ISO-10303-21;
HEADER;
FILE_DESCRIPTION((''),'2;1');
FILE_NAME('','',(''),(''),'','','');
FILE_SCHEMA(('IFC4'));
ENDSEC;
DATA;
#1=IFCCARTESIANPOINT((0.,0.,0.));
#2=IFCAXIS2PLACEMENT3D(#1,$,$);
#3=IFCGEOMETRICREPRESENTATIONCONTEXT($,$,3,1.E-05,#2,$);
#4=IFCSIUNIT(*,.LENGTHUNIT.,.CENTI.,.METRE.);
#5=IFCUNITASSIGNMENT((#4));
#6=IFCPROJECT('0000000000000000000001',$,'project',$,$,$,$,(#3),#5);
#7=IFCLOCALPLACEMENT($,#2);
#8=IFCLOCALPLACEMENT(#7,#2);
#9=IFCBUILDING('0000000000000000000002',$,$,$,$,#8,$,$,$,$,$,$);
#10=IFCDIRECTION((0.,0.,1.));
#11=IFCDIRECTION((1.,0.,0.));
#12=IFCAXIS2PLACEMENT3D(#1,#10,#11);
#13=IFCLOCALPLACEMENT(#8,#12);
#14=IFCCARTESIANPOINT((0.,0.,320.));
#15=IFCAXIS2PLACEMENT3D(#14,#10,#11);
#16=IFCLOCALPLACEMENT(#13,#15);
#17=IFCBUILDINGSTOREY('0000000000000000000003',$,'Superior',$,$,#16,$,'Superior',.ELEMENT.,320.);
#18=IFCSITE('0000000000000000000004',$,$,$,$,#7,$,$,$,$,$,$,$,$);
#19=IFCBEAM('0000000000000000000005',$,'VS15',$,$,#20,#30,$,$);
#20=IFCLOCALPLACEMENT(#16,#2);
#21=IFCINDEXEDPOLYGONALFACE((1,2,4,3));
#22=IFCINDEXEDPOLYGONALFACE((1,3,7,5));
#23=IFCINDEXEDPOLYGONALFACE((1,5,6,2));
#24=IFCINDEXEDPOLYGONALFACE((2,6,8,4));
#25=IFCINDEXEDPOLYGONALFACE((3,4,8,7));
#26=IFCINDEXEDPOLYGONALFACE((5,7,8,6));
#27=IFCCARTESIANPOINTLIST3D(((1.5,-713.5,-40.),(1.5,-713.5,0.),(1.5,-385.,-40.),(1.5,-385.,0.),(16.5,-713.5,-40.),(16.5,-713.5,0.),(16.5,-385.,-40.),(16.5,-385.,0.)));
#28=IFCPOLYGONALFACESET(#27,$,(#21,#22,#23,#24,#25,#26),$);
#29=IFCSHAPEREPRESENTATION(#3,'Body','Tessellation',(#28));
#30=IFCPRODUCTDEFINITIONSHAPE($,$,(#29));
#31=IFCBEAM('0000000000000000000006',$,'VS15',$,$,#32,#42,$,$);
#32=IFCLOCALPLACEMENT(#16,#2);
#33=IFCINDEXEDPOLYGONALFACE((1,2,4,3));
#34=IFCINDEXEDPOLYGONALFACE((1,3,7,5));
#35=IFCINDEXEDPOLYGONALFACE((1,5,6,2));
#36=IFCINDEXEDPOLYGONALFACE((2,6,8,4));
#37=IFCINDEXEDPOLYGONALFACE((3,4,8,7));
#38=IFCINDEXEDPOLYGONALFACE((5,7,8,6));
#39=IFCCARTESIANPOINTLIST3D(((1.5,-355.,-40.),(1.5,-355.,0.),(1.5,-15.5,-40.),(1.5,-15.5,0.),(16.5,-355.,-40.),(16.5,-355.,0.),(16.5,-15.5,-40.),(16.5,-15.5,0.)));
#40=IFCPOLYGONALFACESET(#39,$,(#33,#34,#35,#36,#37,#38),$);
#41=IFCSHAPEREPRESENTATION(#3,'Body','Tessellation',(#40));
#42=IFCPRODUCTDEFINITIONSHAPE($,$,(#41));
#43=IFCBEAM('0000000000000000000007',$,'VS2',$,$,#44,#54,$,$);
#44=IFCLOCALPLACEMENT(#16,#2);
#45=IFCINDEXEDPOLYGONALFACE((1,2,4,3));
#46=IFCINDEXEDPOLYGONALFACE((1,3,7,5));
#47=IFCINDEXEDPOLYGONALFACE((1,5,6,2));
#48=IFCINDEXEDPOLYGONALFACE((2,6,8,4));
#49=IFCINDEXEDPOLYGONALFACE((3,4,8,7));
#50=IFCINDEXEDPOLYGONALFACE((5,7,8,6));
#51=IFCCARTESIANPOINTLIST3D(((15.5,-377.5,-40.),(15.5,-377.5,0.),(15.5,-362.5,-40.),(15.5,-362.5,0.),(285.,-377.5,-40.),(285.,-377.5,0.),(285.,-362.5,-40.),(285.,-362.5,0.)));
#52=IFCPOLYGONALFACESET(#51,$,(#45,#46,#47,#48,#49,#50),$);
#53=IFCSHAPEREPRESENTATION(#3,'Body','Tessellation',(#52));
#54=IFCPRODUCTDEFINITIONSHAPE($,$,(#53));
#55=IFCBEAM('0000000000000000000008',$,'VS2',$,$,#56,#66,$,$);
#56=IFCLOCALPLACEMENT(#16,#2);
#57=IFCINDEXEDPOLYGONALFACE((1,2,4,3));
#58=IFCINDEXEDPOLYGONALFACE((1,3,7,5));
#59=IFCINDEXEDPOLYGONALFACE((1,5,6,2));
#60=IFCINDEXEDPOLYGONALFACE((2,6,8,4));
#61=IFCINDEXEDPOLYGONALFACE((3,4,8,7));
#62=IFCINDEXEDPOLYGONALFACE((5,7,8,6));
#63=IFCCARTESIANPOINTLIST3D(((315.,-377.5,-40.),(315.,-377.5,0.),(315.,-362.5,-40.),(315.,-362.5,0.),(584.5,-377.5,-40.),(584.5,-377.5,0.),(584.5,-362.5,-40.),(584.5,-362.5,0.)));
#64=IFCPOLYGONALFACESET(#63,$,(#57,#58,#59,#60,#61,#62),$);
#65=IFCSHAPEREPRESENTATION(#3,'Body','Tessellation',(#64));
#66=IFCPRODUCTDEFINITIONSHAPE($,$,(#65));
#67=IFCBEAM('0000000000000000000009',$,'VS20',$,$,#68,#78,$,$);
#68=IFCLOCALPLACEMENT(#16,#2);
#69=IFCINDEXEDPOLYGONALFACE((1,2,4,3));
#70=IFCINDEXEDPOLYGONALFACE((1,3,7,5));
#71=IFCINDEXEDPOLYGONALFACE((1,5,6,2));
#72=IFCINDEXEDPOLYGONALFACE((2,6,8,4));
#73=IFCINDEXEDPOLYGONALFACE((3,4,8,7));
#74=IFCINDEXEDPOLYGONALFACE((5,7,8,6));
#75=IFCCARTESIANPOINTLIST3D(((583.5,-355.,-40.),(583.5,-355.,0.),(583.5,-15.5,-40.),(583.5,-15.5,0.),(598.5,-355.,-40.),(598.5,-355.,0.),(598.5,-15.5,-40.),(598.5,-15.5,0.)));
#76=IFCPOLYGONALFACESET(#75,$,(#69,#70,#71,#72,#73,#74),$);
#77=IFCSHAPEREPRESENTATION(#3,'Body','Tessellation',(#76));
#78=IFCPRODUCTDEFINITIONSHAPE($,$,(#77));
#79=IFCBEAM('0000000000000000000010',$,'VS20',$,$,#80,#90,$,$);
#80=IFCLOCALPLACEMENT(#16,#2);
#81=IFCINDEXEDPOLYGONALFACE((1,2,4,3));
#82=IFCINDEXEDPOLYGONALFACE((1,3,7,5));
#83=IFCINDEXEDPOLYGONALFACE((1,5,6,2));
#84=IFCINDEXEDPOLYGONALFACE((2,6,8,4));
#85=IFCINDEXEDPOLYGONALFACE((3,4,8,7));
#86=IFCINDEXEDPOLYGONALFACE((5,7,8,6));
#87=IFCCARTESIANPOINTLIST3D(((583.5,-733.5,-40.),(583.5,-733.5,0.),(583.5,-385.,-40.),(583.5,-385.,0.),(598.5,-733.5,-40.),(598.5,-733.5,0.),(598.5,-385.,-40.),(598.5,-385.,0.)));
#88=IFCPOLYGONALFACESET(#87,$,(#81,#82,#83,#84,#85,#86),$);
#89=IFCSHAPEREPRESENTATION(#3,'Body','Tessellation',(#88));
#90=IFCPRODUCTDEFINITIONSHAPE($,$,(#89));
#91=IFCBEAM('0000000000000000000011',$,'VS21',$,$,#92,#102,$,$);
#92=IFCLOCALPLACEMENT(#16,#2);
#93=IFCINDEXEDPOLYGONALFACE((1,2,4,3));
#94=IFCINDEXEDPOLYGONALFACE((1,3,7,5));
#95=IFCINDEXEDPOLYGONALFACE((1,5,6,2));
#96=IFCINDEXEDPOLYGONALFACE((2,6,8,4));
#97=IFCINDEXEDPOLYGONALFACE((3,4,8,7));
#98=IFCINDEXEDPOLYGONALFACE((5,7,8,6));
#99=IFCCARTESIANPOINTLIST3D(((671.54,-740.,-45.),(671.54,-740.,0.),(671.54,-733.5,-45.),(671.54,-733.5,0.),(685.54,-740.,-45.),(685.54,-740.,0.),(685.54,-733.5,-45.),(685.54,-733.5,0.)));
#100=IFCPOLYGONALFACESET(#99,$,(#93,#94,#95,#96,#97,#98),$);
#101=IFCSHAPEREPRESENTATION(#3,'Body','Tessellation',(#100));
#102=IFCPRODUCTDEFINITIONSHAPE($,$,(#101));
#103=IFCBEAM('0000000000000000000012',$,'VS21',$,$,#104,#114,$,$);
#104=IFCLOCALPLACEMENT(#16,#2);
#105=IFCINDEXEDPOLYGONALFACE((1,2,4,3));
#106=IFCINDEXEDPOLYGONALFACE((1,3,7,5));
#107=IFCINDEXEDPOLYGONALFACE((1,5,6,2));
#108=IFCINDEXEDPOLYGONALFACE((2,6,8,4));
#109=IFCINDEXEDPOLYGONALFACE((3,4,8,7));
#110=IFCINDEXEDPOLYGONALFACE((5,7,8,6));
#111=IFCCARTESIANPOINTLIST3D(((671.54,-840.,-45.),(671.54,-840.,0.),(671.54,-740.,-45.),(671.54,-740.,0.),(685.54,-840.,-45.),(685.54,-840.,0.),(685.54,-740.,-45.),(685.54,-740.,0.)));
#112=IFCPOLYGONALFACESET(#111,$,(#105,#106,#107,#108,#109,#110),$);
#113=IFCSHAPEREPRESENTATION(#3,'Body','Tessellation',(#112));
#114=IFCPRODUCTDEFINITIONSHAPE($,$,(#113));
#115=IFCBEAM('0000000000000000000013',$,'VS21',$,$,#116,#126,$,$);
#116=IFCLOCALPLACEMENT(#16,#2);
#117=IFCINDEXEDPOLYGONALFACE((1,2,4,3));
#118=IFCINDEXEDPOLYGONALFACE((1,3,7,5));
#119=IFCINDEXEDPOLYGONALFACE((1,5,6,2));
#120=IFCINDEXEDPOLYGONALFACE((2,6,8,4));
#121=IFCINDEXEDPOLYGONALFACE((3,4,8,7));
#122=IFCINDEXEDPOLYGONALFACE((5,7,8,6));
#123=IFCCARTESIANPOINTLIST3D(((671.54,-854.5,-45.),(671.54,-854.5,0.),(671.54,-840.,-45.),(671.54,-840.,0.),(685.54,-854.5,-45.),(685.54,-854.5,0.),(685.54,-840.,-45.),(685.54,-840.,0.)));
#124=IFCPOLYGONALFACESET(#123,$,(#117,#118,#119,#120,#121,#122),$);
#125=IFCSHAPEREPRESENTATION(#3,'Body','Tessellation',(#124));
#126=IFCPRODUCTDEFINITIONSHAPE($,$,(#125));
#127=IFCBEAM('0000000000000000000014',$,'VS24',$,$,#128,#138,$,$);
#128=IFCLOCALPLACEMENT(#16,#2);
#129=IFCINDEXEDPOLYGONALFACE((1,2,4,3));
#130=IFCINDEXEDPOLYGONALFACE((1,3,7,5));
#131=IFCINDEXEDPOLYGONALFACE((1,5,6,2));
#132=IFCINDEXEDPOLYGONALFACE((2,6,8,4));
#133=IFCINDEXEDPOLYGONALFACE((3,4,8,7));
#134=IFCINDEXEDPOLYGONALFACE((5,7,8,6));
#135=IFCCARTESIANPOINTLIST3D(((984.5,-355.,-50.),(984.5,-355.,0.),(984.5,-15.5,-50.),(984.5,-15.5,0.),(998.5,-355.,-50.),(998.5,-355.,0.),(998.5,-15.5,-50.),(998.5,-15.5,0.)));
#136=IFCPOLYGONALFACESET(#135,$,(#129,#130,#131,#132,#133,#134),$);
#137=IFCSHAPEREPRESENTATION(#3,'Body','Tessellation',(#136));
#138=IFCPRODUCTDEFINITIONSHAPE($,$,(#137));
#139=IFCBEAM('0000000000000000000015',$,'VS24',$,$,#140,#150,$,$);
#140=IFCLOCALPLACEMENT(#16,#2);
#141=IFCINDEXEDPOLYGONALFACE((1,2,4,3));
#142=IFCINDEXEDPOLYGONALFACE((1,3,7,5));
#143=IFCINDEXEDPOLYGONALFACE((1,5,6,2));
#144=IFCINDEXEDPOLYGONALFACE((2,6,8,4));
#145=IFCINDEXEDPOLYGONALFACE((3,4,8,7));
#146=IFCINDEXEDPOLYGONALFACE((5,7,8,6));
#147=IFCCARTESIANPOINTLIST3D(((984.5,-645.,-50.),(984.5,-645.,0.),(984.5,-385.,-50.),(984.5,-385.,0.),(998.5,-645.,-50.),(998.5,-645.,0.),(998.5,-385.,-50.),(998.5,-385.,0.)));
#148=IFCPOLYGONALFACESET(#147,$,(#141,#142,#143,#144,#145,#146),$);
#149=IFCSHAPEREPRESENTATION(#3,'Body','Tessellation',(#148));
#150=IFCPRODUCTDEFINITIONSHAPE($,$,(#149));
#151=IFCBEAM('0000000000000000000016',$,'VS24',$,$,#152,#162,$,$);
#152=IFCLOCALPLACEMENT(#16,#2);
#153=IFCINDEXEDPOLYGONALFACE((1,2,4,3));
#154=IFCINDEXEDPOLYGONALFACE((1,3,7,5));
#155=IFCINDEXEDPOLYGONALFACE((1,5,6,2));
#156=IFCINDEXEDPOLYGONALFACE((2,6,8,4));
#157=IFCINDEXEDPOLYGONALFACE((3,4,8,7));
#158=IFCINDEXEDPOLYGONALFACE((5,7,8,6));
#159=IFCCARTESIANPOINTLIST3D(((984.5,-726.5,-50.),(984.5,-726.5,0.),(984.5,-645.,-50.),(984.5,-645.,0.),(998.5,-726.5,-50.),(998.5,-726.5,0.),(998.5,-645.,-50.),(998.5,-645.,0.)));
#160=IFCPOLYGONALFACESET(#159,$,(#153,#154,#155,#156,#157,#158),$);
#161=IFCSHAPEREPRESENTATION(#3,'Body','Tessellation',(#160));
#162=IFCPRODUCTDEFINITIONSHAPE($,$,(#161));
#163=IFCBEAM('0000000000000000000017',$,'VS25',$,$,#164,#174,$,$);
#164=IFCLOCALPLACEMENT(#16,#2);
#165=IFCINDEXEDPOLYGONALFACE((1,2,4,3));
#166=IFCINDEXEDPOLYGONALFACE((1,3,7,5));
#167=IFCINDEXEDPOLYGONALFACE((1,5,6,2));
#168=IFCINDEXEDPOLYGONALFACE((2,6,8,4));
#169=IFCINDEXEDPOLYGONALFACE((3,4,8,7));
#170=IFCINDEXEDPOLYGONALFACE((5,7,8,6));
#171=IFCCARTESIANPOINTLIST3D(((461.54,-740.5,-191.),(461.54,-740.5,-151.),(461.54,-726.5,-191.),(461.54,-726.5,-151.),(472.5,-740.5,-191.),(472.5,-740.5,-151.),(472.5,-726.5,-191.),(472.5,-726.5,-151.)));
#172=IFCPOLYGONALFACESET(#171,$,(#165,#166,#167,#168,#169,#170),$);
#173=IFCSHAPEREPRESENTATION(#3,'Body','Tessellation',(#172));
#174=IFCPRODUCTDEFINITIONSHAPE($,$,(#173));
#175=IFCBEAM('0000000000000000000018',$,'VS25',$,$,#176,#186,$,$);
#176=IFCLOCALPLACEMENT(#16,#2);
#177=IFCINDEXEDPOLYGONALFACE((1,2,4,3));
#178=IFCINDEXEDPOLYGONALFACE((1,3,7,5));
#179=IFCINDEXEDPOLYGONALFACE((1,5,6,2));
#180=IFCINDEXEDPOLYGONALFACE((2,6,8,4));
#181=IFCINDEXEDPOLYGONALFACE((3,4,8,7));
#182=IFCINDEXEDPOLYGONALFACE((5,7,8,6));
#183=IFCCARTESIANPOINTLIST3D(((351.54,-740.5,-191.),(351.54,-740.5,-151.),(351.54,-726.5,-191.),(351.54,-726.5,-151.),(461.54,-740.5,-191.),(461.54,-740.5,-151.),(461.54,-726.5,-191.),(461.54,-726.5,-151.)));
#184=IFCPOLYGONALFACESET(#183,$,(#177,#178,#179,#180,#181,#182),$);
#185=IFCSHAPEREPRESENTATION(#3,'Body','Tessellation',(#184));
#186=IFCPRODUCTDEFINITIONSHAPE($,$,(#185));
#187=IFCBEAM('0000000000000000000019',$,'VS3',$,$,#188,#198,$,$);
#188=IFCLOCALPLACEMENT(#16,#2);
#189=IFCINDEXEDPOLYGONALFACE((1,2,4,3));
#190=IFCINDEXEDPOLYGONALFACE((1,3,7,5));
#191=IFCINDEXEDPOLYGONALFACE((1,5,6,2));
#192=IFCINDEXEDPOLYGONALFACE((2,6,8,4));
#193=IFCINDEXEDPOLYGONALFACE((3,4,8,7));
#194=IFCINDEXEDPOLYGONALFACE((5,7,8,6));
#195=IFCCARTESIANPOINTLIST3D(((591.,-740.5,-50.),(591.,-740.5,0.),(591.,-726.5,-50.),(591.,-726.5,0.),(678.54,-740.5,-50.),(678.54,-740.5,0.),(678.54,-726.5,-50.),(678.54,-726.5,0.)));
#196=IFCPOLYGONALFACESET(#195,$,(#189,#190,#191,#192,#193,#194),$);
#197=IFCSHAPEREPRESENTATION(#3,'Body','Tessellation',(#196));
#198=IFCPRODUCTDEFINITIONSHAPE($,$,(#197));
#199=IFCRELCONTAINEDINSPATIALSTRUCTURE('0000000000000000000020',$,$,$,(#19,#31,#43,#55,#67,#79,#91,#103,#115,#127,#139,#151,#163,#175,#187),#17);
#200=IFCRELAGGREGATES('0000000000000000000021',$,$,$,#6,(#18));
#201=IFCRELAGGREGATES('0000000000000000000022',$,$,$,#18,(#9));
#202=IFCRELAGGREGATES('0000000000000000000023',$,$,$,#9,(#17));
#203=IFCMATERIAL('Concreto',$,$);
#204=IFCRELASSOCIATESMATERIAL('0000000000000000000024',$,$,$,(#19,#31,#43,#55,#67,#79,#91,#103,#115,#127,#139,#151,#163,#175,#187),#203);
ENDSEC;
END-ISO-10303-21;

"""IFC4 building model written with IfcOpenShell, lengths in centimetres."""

from ifc_helpers import new_model, si_unit, frame, origin, origin_with_axes, place, context, project, spatial, polyline, outline, extrude, material, element, save


model = new_model("IFC4")

# Units and contexts
context_of_model = context(None, 3, precision=1e-05, world=origin())
ifc_project = project(units=[si_unit("LENGTHUNIT", "METRE", prefix="CENTI")], contexts=[context_of_model])

# Site, building, storey
site_placement = place(None, origin())
site = spatial("IfcSite", under=ifc_project, at=site_placement)
building_placement = place(site_placement, origin())
building = spatial("IfcBuilding", under=site, at=building_placement)
placement = place(building_placement, origin_with_axes())
storey_placement = place(placement, frame((0.0, 0.0, 320.0), z_axis=(0.0, 0.0, 1.0), x_axis=(1.0, 0.0, 0.0)))
storey = spatial("IfcBuildingStorey", under=building, at=storey_placement, Name="Superior", LongName="Superior", CompositionType="ELEMENT", Elevation=320.0)

# Shared definitions
ifc_material = material(Name="Concreto")

# Beams
beam_1_placement = place(storey_placement, frame((9.0, -549.25, 0.0), z_axis=(0.0, 0.0, 1.0), x_axis=(1.0, 0.0, 0.0)))
element("IfcBeam", 1, at=beam_1_placement, inside=storey, material=ifc_material, Name="VS15", context=context_of_model, shape_type="SolidModel", body=[
    extrude(outline(polyline([(-7.5, -20.0), (7.5, -20.0), (7.5, 20.0), (-7.5, 20.0), (-7.5, -20.0)])), frame((0.0, -164.25, -20.0), z_axis=(0.0, 1.0, 0.0), x_axis=(1.0, 0.0, 0.0)), (0.0, 0.0, 1.0), 328.5),
])
beam_2_placement = place(storey_placement, frame((9.0, -185.25, 0.0), z_axis=(0.0, 0.0, 1.0), x_axis=(1.0, 0.0, 0.0)))
element("IfcBeam", 2, at=beam_2_placement, inside=storey, material=ifc_material, Name="VS15", context=context_of_model, shape_type="SolidModel", body=[
    extrude(outline(polyline([(-7.5, -20.0), (7.5, -20.0), (7.5, 20.0), (-7.5, 20.0), (-7.5, -20.0)])), frame((0.0, -169.75, -20.0), z_axis=(0.0, 1.0, 0.0), x_axis=(1.0, 0.0, 0.0)), (0.0, 0.0, 1.0), 339.5),
])
for number, where, z_axis, x_axis, name in (
    (3, (150.25, -370.0, 0.0), (0.0, 0.0, 1.0), (1.0, 0.0, 0.0), "VS2"),
    (4, (449.75, -370.0, 0.0), (0.0, 0.0, 1.0), (1.0, 0.0, 0.0), "VS2"),
):
    element("IfcBeam", number, at=place(storey_placement, frame(where, z_axis=z_axis, x_axis=x_axis)), inside=storey, material=ifc_material, Name=name, context=context_of_model, shape_type="SolidModel", body=[
        extrude(outline(polyline([(-7.5, -20.0), (7.5, -20.0), (7.5, 20.0), (-7.5, 20.0), (-7.5, -20.0)])), frame((-134.75, 0.0, -20.0), z_axis=(1.0, 0.0, 0.0), x_axis=(0.0, -1.0, 0.0)), (0.0, 0.0, 1.0), 269.5),
    ])
beam_3_placement = place(storey_placement, frame((591.0, -185.25, 0.0), z_axis=(0.0, 0.0, 1.0), x_axis=(1.0, 0.0, 0.0)))
element("IfcBeam", 5, at=beam_3_placement, inside=storey, material=ifc_material, Name="VS20", context=context_of_model, shape_type="SolidModel", body=[
    extrude(outline(polyline([(-7.5, -20.0), (7.5, -20.0), (7.5, 20.0), (-7.5, 20.0), (-7.5, -20.0)])), frame((0.0, -169.75, -20.0), z_axis=(0.0, 1.0, 0.0), x_axis=(1.0, 0.0, 0.0)), (0.0, 0.0, 1.0), 339.5),
])
beam_4_placement = place(storey_placement, frame((591.0, -559.25, 0.0), z_axis=(0.0, 0.0, 1.0), x_axis=(1.0, 0.0, 0.0)))
element("IfcBeam", 6, at=beam_4_placement, inside=storey, material=ifc_material, Name="VS20", context=context_of_model, shape_type="SolidModel", body=[
    extrude(outline(polyline([(-7.5, -20.0), (7.5, -20.0), (7.5, 20.0), (-7.5, 20.0), (-7.5, -20.0)])), frame((0.0, -174.25, -20.0), z_axis=(0.0, 1.0, 0.0), x_axis=(1.0, 0.0, 0.0)), (0.0, 0.0, 1.0), 348.5),
])
beam_5_placement = place(storey_placement, frame((678.54, -736.75, 0.0), z_axis=(0.0, 0.0, 1.0), x_axis=(1.0, 0.0, 0.0)))
element("IfcBeam", 7, at=beam_5_placement, inside=storey, material=ifc_material, Name="VS21", context=context_of_model, shape_type="SolidModel", body=[
    extrude(outline(polyline([(-7.0, -22.5), (7.0, -22.5), (7.0, 22.5), (-7.0, 22.5), (-7.0, -22.5)])), frame((0.0, -3.25, -22.5), z_axis=(0.0, 1.0, 0.0), x_axis=(1.0, 0.0, 0.0)), (0.0, 0.0, 1.0), 6.5),
])
beam_6_placement = place(storey_placement, frame((678.54, -790.0, 0.0), z_axis=(0.0, 0.0, 1.0), x_axis=(1.0, 0.0, 0.0)))
element("IfcBeam", 8, at=beam_6_placement, inside=storey, material=ifc_material, Name="VS21", context=context_of_model, shape_type="SolidModel", body=[
    extrude(outline(polyline([(-7.0, -22.5), (7.0, -22.5), (7.0, 22.5), (-7.0, 22.5), (-7.0, -22.5)])), frame((0.0, -50.0, -22.5), z_axis=(0.0, 1.0, 0.0), x_axis=(1.0, 0.0, 0.0)), (0.0, 0.0, 1.0), 100.0),
])
beam_7_placement = place(storey_placement, frame((678.54, -847.25, 0.0), z_axis=(0.0, 0.0, 1.0), x_axis=(1.0, 0.0, 0.0)))
element("IfcBeam", 9, at=beam_7_placement, inside=storey, material=ifc_material, Name="VS21", context=context_of_model, shape_type="SolidModel", body=[
    extrude(outline(polyline([(-7.0, -22.5), (7.0, -22.5), (7.0, 22.5), (-7.0, 22.5), (-7.0, -22.5)])), frame((0.0, -7.25, -22.5), z_axis=(0.0, 1.0, 0.0), x_axis=(1.0, 0.0, 0.0)), (0.0, 0.0, 1.0), 14.5),
])
beam_8_placement = place(storey_placement, frame((991.5, -185.25, 0.0), z_axis=(0.0, 0.0, 1.0), x_axis=(1.0, 0.0, 0.0)))
element("IfcBeam", 10, at=beam_8_placement, inside=storey, material=ifc_material, Name="VS24", context=context_of_model, shape_type="SolidModel", body=[
    extrude(outline(polyline([(-7.0, -25.0), (7.0, -25.0), (7.0, 25.0), (-7.0, 25.0), (-7.0, -25.0)])), frame((0.0, -169.75, -25.0), z_axis=(0.0, 1.0, 0.0), x_axis=(1.0, 0.0, 0.0)), (0.0, 0.0, 1.0), 339.5),
])
beam_9_placement = place(storey_placement, frame((991.5, -515.0, 0.0), z_axis=(0.0, 0.0, 1.0), x_axis=(1.0, 0.0, 0.0)))
element("IfcBeam", 11, at=beam_9_placement, inside=storey, material=ifc_material, Name="VS24", context=context_of_model, shape_type="SolidModel", body=[
    extrude(outline(polyline([(-7.0, -25.0), (7.0, -25.0), (7.0, 25.0), (-7.0, 25.0), (-7.0, -25.0)])), frame((0.0, -130.0, -25.0), z_axis=(0.0, 1.0, 0.0), x_axis=(1.0, 0.0, 0.0)), (0.0, 0.0, 1.0), 260.0),
])
beam_10_placement = place(storey_placement, frame((991.5, -685.75, 0.0), z_axis=(0.0, 0.0, 1.0), x_axis=(1.0, 0.0, 0.0)))
element("IfcBeam", 12, at=beam_10_placement, inside=storey, material=ifc_material, Name="VS24", context=context_of_model, shape_type="SolidModel", body=[
    extrude(outline(polyline([(-7.0, -25.0), (7.0, -25.0), (7.0, 25.0), (-7.0, 25.0), (-7.0, -25.0)])), frame((0.0, -40.75, -25.0), z_axis=(0.0, 1.0, 0.0), x_axis=(1.0, 0.0, 0.0)), (0.0, 0.0, 1.0), 81.5),
])
beam_11_placement = place(storey_placement, frame((467.02, -733.5, -151.0), z_axis=(0.0, 0.0, 1.0), x_axis=(1.0, 0.0, 0.0)))
element("IfcBeam", 13, at=beam_11_placement, inside=storey, material=ifc_material, Name="VS25", context=context_of_model, shape_type="SolidModel", body=[
    extrude(outline(polyline([(-7.0, -20.0), (7.0, -20.0), (7.0, 20.0), (-7.0, 20.0), (-7.0, -20.0)])), frame((-5.48, 0.0, -20.0), z_axis=(1.0, 0.0, 0.0), x_axis=(0.0, -1.0, 0.0)), (0.0, 0.0, 1.0), 10.96),
])
beam_12_placement = place(storey_placement, frame((406.54, -733.5, -151.0), z_axis=(0.0, 0.0, 1.0), x_axis=(1.0, 0.0, 0.0)))
element("IfcBeam", 14, at=beam_12_placement, inside=storey, material=ifc_material, Name="VS25", context=context_of_model, shape_type="SolidModel", body=[
    extrude(outline(polyline([(-7.0, -20.0), (7.0, -20.0), (7.0, 20.0), (-7.0, 20.0), (-7.0, -20.0)])), frame((-55.0, 0.0, -20.0), z_axis=(1.0, 0.0, 0.0), x_axis=(0.0, -1.0, 0.0)), (0.0, 0.0, 1.0), 110.0),
])
beam_13_placement = place(storey_placement, frame((634.77, -733.5, 0.0), z_axis=(0.0, 0.0, 1.0), x_axis=(1.0, 0.0, 0.0)))
element("IfcBeam", 15, at=beam_13_placement, inside=storey, material=ifc_material, Name="VS3", context=context_of_model, shape_type="SolidModel", body=[
    extrude(outline(polyline([(-7.0, -25.0), (7.0, -25.0), (7.0, 25.0), (-7.0, 25.0), (-7.0, -25.0)])), frame((-43.77, 0.0, -25.0), z_axis=(1.0, 0.0, 0.0), x_axis=(0.0, -1.0, 0.0)), (0.0, 0.0, 1.0), 87.54),
])

save(model, "model.ifc")
